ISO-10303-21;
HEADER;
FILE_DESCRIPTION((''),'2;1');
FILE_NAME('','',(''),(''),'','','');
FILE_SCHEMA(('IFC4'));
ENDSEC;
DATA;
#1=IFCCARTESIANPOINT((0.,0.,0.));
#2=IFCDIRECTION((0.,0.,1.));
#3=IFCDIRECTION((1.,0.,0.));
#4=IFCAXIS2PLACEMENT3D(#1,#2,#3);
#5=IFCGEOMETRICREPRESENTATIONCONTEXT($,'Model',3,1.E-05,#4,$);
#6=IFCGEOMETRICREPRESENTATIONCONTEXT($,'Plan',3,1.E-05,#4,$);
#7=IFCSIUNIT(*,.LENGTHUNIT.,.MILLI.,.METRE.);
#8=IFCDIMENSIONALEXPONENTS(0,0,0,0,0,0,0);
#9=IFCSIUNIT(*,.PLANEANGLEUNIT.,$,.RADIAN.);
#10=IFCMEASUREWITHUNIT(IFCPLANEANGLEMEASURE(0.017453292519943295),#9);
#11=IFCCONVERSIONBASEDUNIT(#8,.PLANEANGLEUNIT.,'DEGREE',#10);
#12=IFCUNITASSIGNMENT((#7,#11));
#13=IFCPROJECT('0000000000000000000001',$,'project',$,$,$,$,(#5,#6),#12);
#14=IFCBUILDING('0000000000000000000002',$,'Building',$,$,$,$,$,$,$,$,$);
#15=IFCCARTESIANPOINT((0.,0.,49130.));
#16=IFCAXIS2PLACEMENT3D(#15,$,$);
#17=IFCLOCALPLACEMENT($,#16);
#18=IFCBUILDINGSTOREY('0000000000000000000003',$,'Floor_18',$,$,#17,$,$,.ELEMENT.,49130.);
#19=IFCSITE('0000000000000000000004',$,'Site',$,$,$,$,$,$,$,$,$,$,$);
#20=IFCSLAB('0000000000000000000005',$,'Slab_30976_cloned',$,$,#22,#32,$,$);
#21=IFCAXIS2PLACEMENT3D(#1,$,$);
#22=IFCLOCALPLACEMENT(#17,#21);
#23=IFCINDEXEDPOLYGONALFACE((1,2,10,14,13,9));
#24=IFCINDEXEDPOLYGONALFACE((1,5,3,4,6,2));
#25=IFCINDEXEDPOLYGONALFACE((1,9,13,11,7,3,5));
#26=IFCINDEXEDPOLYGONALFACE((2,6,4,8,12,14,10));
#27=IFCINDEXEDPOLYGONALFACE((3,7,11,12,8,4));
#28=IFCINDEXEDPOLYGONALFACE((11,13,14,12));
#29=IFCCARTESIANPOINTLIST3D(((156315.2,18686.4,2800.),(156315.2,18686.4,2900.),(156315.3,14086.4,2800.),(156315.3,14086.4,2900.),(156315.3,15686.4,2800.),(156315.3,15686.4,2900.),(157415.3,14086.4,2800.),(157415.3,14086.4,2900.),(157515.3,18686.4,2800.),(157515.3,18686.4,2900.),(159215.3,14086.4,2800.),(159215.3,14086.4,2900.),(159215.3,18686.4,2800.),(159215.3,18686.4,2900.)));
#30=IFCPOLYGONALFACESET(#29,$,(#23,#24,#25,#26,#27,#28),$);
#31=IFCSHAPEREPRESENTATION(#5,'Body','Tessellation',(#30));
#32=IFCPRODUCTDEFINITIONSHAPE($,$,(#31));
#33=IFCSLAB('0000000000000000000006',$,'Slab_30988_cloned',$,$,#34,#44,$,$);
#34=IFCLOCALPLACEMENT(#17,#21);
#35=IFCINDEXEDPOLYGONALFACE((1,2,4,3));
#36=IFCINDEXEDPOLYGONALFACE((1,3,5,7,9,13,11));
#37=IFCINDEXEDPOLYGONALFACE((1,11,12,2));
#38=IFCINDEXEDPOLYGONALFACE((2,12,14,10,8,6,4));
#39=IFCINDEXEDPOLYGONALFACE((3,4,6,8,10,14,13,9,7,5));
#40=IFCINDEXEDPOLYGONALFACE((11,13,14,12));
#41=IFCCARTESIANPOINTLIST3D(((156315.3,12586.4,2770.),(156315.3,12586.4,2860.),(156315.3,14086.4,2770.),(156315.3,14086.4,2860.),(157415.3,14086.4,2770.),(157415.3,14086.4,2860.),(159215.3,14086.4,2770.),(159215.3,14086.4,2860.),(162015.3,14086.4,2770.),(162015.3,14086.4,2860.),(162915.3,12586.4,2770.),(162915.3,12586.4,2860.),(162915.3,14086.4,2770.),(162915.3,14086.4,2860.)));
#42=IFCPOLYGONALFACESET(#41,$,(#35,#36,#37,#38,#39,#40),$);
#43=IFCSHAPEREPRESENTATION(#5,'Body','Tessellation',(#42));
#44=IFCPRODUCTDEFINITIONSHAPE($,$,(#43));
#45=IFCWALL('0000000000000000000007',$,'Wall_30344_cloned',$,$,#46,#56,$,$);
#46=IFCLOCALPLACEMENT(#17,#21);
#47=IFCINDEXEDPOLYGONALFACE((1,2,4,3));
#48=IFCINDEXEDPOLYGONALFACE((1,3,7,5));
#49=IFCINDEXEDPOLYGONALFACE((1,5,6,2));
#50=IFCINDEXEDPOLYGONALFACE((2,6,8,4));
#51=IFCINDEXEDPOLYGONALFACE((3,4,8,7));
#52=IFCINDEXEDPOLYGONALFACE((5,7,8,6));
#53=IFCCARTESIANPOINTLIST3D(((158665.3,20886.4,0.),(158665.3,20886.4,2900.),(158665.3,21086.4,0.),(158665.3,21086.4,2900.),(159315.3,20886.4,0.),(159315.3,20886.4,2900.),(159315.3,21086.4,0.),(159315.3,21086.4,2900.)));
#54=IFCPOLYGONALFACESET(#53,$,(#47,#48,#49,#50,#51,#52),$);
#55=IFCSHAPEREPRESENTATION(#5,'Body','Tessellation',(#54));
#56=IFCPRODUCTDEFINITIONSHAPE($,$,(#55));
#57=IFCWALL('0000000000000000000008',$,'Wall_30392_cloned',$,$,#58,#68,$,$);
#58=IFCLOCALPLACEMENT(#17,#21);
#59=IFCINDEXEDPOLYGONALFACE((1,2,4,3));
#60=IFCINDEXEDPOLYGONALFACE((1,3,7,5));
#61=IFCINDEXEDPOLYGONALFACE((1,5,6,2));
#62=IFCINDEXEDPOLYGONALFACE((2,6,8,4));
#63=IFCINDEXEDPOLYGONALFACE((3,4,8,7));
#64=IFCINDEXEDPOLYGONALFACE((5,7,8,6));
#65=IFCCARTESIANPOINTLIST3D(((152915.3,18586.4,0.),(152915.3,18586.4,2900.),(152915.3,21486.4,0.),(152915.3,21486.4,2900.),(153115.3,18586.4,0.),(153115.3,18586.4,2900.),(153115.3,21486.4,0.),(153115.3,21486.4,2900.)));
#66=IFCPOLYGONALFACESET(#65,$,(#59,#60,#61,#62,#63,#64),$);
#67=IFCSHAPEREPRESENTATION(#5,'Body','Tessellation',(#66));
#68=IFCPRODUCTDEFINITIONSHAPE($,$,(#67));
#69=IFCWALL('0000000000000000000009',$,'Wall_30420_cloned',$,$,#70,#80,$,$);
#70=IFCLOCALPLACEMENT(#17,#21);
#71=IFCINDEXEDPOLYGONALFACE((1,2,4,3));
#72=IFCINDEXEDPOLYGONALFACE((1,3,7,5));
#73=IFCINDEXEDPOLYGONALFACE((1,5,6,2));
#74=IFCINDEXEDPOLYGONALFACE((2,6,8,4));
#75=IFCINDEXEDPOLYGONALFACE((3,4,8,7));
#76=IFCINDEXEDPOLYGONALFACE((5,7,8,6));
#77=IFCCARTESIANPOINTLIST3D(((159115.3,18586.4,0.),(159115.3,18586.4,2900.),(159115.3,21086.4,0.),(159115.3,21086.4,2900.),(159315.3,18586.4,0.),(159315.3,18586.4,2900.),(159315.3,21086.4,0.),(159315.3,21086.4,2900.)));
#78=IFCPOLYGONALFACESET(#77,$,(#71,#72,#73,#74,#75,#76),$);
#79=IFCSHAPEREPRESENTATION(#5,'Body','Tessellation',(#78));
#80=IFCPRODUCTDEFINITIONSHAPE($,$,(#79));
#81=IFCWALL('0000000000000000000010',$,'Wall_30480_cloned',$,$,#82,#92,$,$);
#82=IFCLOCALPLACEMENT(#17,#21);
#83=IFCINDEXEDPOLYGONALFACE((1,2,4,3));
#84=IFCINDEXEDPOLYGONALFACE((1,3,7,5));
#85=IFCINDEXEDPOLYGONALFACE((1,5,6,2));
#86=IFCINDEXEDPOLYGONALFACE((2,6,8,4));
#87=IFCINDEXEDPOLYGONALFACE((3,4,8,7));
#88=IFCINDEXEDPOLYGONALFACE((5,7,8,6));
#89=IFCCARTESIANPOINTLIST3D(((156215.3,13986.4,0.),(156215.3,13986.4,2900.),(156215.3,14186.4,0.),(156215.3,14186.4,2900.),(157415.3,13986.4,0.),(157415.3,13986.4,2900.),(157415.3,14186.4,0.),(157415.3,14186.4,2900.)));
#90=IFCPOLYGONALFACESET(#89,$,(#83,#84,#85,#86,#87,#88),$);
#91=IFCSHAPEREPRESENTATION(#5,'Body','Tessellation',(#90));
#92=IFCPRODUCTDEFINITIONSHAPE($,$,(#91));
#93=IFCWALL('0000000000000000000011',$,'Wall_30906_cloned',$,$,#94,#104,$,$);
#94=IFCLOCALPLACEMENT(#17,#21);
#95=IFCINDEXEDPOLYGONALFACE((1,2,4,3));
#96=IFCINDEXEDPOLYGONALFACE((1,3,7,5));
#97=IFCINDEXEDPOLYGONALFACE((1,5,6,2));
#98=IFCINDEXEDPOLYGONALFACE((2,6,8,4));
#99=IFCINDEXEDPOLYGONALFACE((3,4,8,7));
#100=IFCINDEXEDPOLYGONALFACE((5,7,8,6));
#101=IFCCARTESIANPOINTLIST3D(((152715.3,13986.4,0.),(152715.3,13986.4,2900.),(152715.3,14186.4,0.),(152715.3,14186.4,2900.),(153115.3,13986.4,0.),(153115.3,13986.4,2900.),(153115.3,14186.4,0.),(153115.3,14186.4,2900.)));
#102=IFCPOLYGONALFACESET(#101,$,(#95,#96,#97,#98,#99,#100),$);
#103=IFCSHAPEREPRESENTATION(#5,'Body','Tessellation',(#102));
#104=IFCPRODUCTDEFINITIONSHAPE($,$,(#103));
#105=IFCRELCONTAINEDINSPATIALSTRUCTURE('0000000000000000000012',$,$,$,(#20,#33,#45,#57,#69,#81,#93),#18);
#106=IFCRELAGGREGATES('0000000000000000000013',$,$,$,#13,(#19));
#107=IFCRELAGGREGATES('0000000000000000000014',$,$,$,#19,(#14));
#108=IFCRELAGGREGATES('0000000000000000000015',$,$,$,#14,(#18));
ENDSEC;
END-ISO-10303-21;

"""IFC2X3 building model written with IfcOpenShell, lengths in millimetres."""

from ifc_helpers import new_model, entity, si_unit, converted_unit, frame, origin_with_axes, origin_2d, place, context, project, spatial, polyline, rectangle, outline, extrude, source, transform, mapped, element, save


model = new_model("IFC2X3")

# Units and contexts
model_context = context("Model", 3, precision=1e-05, world=origin_with_axes())
plan_context = context("Plan", 3, precision=1e-05, world=origin_with_axes())
ifc_project = project(units=[si_unit("LENGTHUNIT", "METRE", prefix="MILLI"), converted_unit("PLANEANGLEUNIT", "DEGREE", entity("IfcPlaneAngleMeasure", 0.017453292519943295), si_unit("PLANEANGLEUNIT", "RADIAN"), dimensions=[0, 0, 0, 0, 0, 0, 0])], contexts=[model_context, plan_context])

# Site, building, storey
site = spatial("IfcSite", under=ifc_project, Name="Site")
building = spatial("IfcBuilding", under=site, Name="Building")
storey_placement = place(None, frame((0.0, 0.0, 49130.0)))
storey = spatial("IfcBuildingStorey", under=building, at=storey_placement, Name="Floor_18", CompositionType="ELEMENT", Elevation=49130.0)

# Slabs
shared_shape_1 = source(origin_with_axes(), model_context, "Body", "SweptSolid", [
    extrude(outline(polyline([(0.0, 0.0), (3000.0, 0.0), (4600.0, -0.1), (4600.0, 1099.9), (4600.1, 2899.9), (0.1, 2900.1), (0.0, 1200.1)])), origin_with_axes(), (0.0, 0.0, 1.0), 100.0),
])
slab_1_placement = place(storey_placement, frame((156315.2, 18686.4, 2800.0), z_axis=(0.0, 0.0, 1.0), x_axis=(0.108, -2999.994, 0.0)))
element("IfcSlab", 1, at=slab_1_placement, inside=storey, Name="Slab_30976_cloned", context=model_context, shape_type="MappedRepresentation", body=[
    mapped(shared_shape_1, transform((0.0, 0.0, 0.0), x_axis=(1.0, 0.0, 0.0), y_axis=(0.0, 1.0, 0.0), z_axis=(0.0, 0.0, 1.0), scale=1.0)),
])
shared_shape_2 = source(origin_with_axes(), model_context, "Body", "SweptSolid", [
    extrude(outline(polyline([(0.0, 0.0), (1500.0, 0.0), (1500.1, 6600.0), (0.1, 6600.0), (0.1, 5700.0), (0.1, 2900.0), (0.0, 1100.0)])), origin_with_axes(), (0.0, 0.0, 1.0), 90.0),
])
slab_2_placement = place(storey_placement, frame((156315.3, 14086.4, 2770.0), z_axis=(0.0, 0.0, 1.0), x_axis=(0.029, -1500.0, 0.0)))
element("IfcSlab", 2, at=slab_2_placement, inside=storey, Name="Slab_30988_cloned", context=model_context, shape_type="MappedRepresentation", body=[
    mapped(shared_shape_2, transform((0.0, 0.0, 0.0), x_axis=(1.0, 0.0, 0.0), y_axis=(0.0, 1.0, 0.0), z_axis=(0.0, 0.0, 1.0), scale=1.0)),
])

# Walls
shared_shape_3 = source(origin_with_axes(), model_context, "Body", "SweptSolid", [
    extrude(rectangle(XDim=650.0, YDim=200.0, at=origin_2d()), origin_with_axes(), (0.0, 0.0, 1.0), 2900.0),
])
wall_1_placement = place(storey_placement, frame((158990.3, 20986.4, 0.0), z_axis=(0.0, 0.0, 1.0), x_axis=(650.0, 0.0, 0.0)))
element("IfcWall", 3, at=wall_1_placement, inside=storey, Name="Wall_30344_cloned", context=model_context, shape_type="MappedRepresentation", body=[
    mapped(shared_shape_3, transform((0.0, 0.0, 0.0), x_axis=(1.0, 0.0, 0.0), y_axis=(0.0, 1.0, 0.0), z_axis=(0.0, 0.0, 1.0), scale=1.0)),
])
shared_shape_4 = source(origin_with_axes(), model_context, "Body", "SweptSolid", [
    extrude(rectangle(XDim=2900.0, YDim=200.0, at=origin_2d()), origin_with_axes(), (0.0, 0.0, 1.0), 2900.0),
])
wall_2_placement = place(storey_placement, frame((153015.3, 20036.4, 0.0), z_axis=(0.0, 0.0, 1.0), x_axis=(0.0, 2900.0, 0.0)))
element("IfcWall", 4, at=wall_2_placement, inside=storey, Name="Wall_30392_cloned", context=model_context, shape_type="MappedRepresentation", body=[
    mapped(shared_shape_4, transform((0.0, 0.0, 0.0), x_axis=(1.0, 0.0, 0.0), y_axis=(0.0, 1.0, 0.0), z_axis=(0.0, 0.0, 1.0), scale=1.0)),
])
shared_shape_5 = source(origin_with_axes(), model_context, "Body", "SweptSolid", [
    extrude(rectangle(XDim=2500.0, YDim=200.0, at=origin_2d()), origin_with_axes(), (0.0, 0.0, 1.0), 2900.0),
])
wall_3_placement = place(storey_placement, frame((159215.3, 19836.4, 0.0), z_axis=(0.0, 0.0, 1.0), x_axis=(0.0, 2500.0, 0.0)))
element("IfcWall", 5, at=wall_3_placement, inside=storey, Name="Wall_30420_cloned", context=model_context, shape_type="MappedRepresentation", body=[
    mapped(shared_shape_5, transform((0.0, 0.0, 0.0), x_axis=(1.0, 0.0, 0.0), y_axis=(0.0, 1.0, 0.0), z_axis=(0.0, 0.0, 1.0), scale=1.0)),
])
shared_shape_6 = source(origin_with_axes(), model_context, "Body", "SweptSolid", [
    extrude(rectangle(XDim=1200.0, YDim=200.0, at=origin_2d()), origin_with_axes(), (0.0, 0.0, 1.0), 2900.0),
])
wall_4_placement = place(storey_placement, frame((156815.3, 14086.4, 0.0), z_axis=(0.0, 0.0, 1.0), x_axis=(1200.022782, 0.0, 0.0)))
element("IfcWall", 6, at=wall_4_placement, inside=storey, Name="Wall_30480_cloned", context=model_context, shape_type="MappedRepresentation", body=[
    mapped(shared_shape_6, transform((0.0, 0.0, 0.0), x_axis=(1.0, 0.0, 0.0), y_axis=(0.0, 1.0, 0.0), z_axis=(0.0, 0.0, 1.0), scale=1.0)),
])
shared_shape_7 = source(origin_with_axes(), model_context, "Body", "SweptSolid", [
    extrude(rectangle(XDim=400.0, YDim=200.0, at=origin_2d()), origin_with_axes(), (0.0, 0.0, 1.0), 2900.0),
])
wall_5_placement = place(storey_placement, frame((152915.3, 14086.4, 0.0), z_axis=(0.0, 0.0, 1.0), x_axis=(400.0, 0.0, 0.0)))
element("IfcWall", 7, at=wall_5_placement, inside=storey, Name="Wall_30906_cloned", context=model_context, shape_type="MappedRepresentation", body=[
    mapped(shared_shape_7, transform((0.0, 0.0, 0.0), x_axis=(1.0, 0.0, 0.0), y_axis=(0.0, 1.0, 0.0), z_axis=(0.0, 0.0, 1.0), scale=1.0)),
])

save(model, "model.ifc")
